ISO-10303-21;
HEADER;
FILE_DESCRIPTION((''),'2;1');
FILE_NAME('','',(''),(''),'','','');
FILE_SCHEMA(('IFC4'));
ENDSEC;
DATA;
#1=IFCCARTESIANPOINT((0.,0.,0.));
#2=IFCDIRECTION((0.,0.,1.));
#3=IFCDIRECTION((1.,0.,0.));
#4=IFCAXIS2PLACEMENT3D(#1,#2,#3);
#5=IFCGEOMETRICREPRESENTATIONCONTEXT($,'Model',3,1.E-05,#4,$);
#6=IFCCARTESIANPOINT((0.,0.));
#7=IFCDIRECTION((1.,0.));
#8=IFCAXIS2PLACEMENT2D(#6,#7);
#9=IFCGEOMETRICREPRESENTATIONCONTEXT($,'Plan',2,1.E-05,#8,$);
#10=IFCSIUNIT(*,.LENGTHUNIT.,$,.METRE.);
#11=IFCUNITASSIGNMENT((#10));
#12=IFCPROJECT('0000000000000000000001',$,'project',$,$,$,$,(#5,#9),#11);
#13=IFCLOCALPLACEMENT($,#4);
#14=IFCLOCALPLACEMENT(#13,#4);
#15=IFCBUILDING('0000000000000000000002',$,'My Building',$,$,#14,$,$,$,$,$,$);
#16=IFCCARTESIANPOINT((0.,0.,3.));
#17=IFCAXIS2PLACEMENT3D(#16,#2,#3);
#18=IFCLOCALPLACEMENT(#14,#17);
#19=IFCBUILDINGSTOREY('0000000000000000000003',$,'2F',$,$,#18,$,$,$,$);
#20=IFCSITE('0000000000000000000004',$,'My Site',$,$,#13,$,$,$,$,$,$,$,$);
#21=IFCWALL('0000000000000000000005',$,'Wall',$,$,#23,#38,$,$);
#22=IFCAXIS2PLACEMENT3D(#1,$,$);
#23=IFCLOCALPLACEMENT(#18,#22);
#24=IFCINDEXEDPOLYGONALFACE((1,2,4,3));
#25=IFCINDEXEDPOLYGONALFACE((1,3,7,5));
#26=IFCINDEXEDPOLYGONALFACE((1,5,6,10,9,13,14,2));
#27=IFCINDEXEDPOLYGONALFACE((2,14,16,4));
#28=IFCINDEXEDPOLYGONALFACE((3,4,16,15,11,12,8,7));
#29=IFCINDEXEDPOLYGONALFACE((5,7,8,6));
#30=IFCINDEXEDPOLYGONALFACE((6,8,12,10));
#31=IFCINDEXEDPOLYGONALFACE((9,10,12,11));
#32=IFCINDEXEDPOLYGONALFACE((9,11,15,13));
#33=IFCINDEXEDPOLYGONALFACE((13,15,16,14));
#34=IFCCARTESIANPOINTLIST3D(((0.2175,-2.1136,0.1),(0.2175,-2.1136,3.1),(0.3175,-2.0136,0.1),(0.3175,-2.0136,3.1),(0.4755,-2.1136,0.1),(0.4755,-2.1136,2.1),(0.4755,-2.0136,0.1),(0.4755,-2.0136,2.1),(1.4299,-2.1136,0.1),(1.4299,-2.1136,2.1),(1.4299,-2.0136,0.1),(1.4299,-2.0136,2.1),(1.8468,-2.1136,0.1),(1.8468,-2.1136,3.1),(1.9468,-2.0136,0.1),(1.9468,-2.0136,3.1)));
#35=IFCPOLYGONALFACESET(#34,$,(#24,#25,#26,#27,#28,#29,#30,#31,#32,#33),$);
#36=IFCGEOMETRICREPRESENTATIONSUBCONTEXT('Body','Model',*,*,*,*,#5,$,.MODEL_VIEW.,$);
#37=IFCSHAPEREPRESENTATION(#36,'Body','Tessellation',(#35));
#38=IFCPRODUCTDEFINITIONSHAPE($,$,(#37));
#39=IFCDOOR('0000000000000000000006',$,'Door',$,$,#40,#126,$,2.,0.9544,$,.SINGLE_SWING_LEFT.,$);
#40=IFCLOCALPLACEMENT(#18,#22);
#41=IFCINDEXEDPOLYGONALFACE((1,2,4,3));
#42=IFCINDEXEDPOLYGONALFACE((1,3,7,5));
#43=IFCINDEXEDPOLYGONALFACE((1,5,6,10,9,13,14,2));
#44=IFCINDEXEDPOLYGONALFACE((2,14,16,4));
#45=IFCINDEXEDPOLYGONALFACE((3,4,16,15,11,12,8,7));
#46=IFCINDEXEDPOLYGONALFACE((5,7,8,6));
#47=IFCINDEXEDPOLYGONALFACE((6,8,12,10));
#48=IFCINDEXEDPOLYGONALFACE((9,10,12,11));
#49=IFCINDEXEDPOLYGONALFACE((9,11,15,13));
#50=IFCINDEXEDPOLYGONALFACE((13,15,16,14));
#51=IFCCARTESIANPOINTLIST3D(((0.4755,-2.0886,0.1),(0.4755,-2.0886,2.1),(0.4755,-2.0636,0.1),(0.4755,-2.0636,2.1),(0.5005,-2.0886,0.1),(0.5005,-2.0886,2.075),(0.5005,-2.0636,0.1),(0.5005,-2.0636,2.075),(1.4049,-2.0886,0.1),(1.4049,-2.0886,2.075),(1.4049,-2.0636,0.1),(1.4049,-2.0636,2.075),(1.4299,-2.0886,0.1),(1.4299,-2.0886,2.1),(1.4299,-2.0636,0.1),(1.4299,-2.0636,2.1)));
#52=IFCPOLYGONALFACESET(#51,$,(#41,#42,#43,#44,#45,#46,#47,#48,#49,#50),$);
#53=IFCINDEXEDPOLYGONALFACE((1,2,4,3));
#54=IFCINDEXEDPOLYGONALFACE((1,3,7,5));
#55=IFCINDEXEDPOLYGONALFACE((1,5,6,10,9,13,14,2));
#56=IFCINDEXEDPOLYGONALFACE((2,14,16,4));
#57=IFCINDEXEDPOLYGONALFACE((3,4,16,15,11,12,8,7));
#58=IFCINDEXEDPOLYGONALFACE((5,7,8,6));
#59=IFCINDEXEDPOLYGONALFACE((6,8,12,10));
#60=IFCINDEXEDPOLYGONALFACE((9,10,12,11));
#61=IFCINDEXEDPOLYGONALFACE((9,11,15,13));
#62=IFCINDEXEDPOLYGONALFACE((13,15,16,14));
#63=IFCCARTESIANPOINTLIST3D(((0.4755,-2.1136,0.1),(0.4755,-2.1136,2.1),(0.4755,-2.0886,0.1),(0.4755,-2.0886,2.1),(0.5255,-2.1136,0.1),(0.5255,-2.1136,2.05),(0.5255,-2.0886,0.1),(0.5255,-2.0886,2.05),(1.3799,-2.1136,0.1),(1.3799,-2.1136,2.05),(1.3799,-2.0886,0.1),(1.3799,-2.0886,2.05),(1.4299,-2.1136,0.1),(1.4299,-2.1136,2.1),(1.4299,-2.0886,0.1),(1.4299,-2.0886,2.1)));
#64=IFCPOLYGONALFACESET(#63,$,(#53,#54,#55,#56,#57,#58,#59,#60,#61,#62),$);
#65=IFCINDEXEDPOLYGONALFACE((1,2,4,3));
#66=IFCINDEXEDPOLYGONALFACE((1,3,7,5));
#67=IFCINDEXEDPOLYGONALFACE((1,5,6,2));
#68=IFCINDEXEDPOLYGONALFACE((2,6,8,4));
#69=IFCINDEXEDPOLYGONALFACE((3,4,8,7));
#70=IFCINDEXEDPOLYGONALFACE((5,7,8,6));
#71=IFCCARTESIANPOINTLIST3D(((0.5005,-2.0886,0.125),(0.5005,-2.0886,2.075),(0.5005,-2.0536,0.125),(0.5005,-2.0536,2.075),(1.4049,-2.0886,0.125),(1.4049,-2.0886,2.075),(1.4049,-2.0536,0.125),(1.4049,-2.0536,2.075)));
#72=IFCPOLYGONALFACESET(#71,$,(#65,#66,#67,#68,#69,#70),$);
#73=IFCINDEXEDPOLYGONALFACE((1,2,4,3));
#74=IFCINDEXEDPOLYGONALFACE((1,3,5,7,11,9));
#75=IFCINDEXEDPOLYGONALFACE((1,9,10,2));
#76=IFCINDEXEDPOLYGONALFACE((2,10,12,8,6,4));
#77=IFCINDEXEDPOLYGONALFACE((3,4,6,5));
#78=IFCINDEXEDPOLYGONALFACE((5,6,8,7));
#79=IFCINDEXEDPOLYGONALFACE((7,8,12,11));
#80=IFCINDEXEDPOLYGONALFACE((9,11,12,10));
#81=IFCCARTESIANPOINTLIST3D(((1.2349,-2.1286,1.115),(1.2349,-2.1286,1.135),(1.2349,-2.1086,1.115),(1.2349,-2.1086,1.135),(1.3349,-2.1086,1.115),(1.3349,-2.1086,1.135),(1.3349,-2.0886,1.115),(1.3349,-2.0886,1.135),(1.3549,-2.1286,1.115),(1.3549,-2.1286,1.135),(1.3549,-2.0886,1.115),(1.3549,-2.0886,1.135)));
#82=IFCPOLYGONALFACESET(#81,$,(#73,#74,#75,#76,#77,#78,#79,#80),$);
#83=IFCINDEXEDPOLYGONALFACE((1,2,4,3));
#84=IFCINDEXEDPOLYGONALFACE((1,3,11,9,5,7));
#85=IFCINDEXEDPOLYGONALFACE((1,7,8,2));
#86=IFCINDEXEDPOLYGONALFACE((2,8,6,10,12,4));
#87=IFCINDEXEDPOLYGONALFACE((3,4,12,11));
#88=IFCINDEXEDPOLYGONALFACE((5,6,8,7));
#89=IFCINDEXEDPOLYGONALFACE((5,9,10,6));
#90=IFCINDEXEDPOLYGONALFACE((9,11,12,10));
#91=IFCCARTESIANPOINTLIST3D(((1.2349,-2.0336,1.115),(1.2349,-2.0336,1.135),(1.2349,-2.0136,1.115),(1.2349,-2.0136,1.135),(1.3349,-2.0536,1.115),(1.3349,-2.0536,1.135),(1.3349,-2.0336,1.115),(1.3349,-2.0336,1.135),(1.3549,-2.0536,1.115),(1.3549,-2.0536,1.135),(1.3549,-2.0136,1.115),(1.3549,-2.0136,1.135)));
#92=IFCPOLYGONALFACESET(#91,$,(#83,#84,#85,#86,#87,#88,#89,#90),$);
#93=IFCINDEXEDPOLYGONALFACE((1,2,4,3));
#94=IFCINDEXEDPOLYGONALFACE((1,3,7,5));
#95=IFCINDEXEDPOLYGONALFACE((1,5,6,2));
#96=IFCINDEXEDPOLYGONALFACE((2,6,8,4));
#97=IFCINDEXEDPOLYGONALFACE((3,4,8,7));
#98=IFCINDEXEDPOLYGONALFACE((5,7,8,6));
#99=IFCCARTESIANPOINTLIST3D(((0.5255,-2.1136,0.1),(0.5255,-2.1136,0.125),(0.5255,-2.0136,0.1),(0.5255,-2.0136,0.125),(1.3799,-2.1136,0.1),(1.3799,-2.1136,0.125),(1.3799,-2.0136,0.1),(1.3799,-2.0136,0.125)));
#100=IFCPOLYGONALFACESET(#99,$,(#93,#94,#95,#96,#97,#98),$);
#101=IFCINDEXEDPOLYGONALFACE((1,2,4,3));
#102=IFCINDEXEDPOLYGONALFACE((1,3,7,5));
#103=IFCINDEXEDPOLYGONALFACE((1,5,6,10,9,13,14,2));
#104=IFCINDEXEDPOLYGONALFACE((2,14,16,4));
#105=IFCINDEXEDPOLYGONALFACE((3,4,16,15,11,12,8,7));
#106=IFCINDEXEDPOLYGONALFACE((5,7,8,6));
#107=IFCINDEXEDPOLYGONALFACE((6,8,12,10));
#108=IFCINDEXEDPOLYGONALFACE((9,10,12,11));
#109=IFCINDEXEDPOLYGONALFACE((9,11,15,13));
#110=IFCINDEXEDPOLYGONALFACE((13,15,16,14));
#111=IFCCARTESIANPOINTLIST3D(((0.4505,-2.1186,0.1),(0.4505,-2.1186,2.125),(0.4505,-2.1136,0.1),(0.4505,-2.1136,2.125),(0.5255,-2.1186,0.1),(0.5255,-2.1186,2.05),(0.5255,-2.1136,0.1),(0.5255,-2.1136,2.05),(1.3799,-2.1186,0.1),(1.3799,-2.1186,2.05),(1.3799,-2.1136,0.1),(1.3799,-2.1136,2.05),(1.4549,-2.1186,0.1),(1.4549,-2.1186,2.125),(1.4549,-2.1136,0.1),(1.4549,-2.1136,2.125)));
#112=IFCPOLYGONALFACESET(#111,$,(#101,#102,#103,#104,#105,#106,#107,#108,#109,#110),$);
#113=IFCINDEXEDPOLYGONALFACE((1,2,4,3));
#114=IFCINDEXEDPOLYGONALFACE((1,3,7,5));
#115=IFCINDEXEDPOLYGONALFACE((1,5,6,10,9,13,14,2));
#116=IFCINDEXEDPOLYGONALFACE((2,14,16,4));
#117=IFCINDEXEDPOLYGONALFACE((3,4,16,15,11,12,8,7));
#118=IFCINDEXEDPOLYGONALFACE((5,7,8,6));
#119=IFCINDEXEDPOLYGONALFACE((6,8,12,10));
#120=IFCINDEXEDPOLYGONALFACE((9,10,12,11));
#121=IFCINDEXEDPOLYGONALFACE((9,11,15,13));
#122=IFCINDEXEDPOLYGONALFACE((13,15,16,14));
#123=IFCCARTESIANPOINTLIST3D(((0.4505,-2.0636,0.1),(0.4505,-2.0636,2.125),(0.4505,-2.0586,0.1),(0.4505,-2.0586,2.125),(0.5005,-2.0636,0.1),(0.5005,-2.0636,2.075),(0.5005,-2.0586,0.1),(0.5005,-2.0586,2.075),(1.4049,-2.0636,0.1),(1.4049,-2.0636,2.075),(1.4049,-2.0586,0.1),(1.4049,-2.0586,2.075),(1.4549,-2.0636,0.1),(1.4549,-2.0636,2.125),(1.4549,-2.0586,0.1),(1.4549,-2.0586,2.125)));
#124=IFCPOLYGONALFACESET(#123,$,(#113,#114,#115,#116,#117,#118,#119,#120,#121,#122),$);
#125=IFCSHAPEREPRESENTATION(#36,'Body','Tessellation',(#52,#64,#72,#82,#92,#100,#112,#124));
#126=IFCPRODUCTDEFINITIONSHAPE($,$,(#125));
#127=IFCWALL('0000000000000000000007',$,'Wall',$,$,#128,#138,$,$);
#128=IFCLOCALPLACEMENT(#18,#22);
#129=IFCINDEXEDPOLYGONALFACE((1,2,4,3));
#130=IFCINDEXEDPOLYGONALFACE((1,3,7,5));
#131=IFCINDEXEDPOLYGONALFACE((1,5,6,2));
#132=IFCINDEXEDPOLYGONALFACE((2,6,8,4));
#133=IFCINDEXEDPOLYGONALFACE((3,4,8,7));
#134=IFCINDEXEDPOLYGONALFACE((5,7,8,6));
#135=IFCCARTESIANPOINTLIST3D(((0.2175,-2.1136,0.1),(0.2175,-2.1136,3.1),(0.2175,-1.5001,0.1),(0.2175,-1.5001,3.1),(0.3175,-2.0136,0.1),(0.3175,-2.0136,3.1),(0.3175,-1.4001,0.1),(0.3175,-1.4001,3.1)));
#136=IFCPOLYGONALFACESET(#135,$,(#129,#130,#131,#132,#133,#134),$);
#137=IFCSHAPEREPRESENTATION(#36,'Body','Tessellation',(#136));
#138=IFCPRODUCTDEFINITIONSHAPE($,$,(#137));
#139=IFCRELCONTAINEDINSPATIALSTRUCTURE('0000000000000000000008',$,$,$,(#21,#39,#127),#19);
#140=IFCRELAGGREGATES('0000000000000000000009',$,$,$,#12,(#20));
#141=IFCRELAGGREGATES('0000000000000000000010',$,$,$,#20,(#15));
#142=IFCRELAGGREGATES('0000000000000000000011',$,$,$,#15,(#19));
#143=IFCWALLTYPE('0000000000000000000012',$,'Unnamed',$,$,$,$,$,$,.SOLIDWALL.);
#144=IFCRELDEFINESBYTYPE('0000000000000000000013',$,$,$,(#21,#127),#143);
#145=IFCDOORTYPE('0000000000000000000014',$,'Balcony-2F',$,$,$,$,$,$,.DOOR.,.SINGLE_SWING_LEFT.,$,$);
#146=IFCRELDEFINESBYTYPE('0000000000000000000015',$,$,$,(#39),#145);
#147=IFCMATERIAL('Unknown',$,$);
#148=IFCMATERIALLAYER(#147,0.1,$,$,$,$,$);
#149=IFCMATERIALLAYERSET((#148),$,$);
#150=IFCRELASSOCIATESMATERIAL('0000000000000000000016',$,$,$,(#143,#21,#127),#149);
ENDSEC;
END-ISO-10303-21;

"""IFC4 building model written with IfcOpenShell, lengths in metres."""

from ifc_helpers import new_model, entity, si_unit, frame, origin_with_axes, origin_2d_with_axis, place, context, subcontext, project, spatial, line, indexed_curve, outline, extrude, shape, source, transform, mapped, material, layer, layer_set, layer_usage, type_object, type_shapes, element, fill, save


model = new_model("IFC4")

# Units and contexts
model_context = context("Model", 3, precision=1e-05, world=origin_with_axes())
plan_context = context("Plan", 2, precision=1e-05, world=origin_2d_with_axis())
body_context_1 = subcontext(model_context, "Body", "Model", "MODEL_VIEW")
body_context_2 = subcontext(plan_context, "Body", "Plan", "PLAN_VIEW")
ifc_project = project(units=[si_unit("LENGTHUNIT", "METRE")], contexts=[model_context, plan_context])

# Site, building, storey
site_placement = place(None, origin_with_axes())
site = spatial("IfcSite", under=ifc_project, at=site_placement, Name="My Site")
building_placement = place(site_placement, origin_with_axes())
building = spatial("IfcBuilding", under=site, at=building_placement, Name="My Building")
storey_placement = place(building_placement, frame((0.0, 0.0, 3.0), z_axis=(0.0, 0.0, 1.0), x_axis=(1.0, 0.0, 0.0)))
storey = spatial("IfcBuildingStorey", under=building, at=storey_placement, Name="2F")

# Shared definitions
ifc_material = material(Name="Unknown")

# Shared definitions
ifc_layer_1 = layer(ifc_material, 0.1)
ifc_layer_set_1 = layer_set([ifc_layer_1])
wall_type = type_object("IfcWallType", Name="Unnamed", PredefinedType="SOLIDWALL", material=ifc_layer_set_1)

# Wall, opening, door
ifc_layer_usage_1 = layer_usage(ifc_layer_set_1, "AXIS2", "POSITIVE", 0.0)
wall_1_placement = place(storey_placement, frame((1.9468, -2.0136, 0.1), z_axis=(0.0, 0.0, 1.0), x_axis=(-1.0, 0.0, 0.0)))
wall_1 = element("IfcWall", 1, at=wall_1_placement, inside=storey, type_object=wall_type, material=ifc_layer_usage_1, Name="Wall", context=body_context_1, shape_type="SweptSolid", body=[
    extrude(outline(indexed_curve([(0.0, 0.0), (0.1, 0.1), (1.7294, 0.1), (1.6294, 0.0)], segments=[line(1, 2, 3, 4, 1)])), origin_with_axes(), (0.0, 0.0, 1.0), 3.0),
])
shared_shape_1 = source(origin_with_axes(), body_context_1, "Body", "SweptSolid", [
    extrude(outline(indexed_curve([(0.0, 0.0), (0.9544, 0.0), (0.9544, 2.0), (0.0, 2.0)], segments=[line(1, 2, 3, 4, 1)])), frame((0.0, -0.6, 0.0), z_axis=(0.0, -1.0, 0.0), x_axis=(1.0, 0.0, 0.0)), (0.0, 0.0, -1.0), 1.2),
])
opening_1_placement = place(wall_1_placement, frame((1.4713, 0.1, 0.0), z_axis=(0.0, 0.0, 1.0), x_axis=(-1.0, 0.0, 0.0)))
opening_1 = element("IfcOpeningElement", 2, at=opening_1_placement, cuts=wall_1, PredefinedType="OPENING", context=body_context_1, shape_type="MappedRepresentation", body=[
    mapped(shared_shape_1, transform((0.0, 0.0, 0.0), x_axis=(1.0, 0.0, 0.0), y_axis=(0.0, 1.0, 0.0), z_axis=(0.0, 0.0, 1.0), scale=1.0)),
])
door_type_1 = type_object("IfcDoorType", Name="Balcony-2F", OperationType="SINGLE_SWING_LEFT", PredefinedType="DOOR")
shared_shape_2 = source(origin_with_axes(), body_context_1, "Body", "SweptSolid", [
    extrude(outline(indexed_curve([(0.0, 0.0), (0.0, 2.0), (0.9544, 2.0), (0.9544, 0.0), (0.9294, 0.0), (0.9294, 1.975), (0.025, 1.975), (0.025, 0.0)], segments=[line(1, 2, 3, 4, 5, 6, 7, 8, 1)])), frame((0.0, 0.025, 0.0), z_axis=(0.0, -1.0, 0.0), x_axis=(1.0, 0.0, 0.0)), (0.0, 0.0, -1.0), 0.025),
    extrude(outline(indexed_curve([(0.0, 0.0), (0.0, 2.0), (0.9544, 2.0), (0.9544, 0.0), (0.9044, 0.0), (0.9044, 1.95), (0.05, 1.95), (0.05, 0.0)], segments=[line(1, 2, 3, 4, 5, 6, 7, 8, 1)])), frame((0.0, 0.0, 0.0), z_axis=(0.0, -1.0, 0.0), x_axis=(1.0, 0.0, 0.0)), (0.0, 0.0, -1.0), 0.025),
    extrude(outline(indexed_curve([(0.0, 0.0), (0.9044, 0.0), (0.9044, 0.035), (0.0, 0.035)], segments=[line(1, 2, 3, 4, 1)])), frame((0.025, 0.025, 0.025), z_axis=(0.0, 0.0, 1.0), x_axis=(1.0, 0.0, 0.0)), (0.0, 0.0, 1.0), 1.95),
    extrude(outline(indexed_curve([(0.0, 0.0), (0.0, -0.04), (-0.12, -0.04), (-0.12, -0.02), (-0.02, -0.02), (-0.02, 0.0)], segments=[line(1, 2, 3, 4, 5, 6, 1)])), frame((0.8794, 0.025, 1.015), z_axis=(0.0, 0.0, 1.0), x_axis=(1.0, 0.0, 0.0)), (0.0, 0.0, 1.0), 0.02),
    extrude(outline(indexed_curve([(0.0, 0.0), (0.0, 0.04), (-0.12, 0.04), (-0.12, 0.02), (-0.02, 0.02), (-0.02, 0.0)], segments=[line(1, 2, 3, 4, 5, 6, 1)])), frame((0.8794, 0.06, 1.015), z_axis=(0.0, 0.0, 1.0), x_axis=(1.0, 0.0, 0.0)), (0.0, 0.0, 1.0), 0.02),
    extrude(outline(indexed_curve([(0.0, 0.0), (0.8544, 0.0), (0.8544, 0.1), (0.0, 0.1)], segments=[line(1, 2, 3, 4, 1)])), frame((0.05, 0.0, 0.0), z_axis=(0.0, 0.0, 1.0), x_axis=(1.0, 0.0, 0.0)), (0.0, 0.0, 1.0), 0.025),
    extrude(outline(indexed_curve([(0.0, 0.0), (0.0, 2.025), (1.0044, 2.025), (1.0044, 0.0), (0.9294, 0.0), (0.9294, 1.95), (0.075, 1.95), (0.075, 0.0)], segments=[line(1, 2, 3, 4, 5, 6, 7, 8, 1)])), frame((-0.025, -0.005, 0.0), z_axis=(0.0, -1.0, 0.0), x_axis=(1.0, 0.0, 0.0)), (0.0, 0.0, -1.0), 0.005),
    extrude(outline(indexed_curve([(0.0, 0.0), (0.0, 2.025), (1.0044, 2.025), (1.0044, 0.0), (0.9544, 0.0), (0.9544, 1.975), (0.05, 1.975), (0.05, 0.0)], segments=[line(1, 2, 3, 4, 5, 6, 7, 8, 1)])), frame((-0.025, 0.05, 0.0), z_axis=(0.0, -1.0, 0.0), x_axis=(1.0, 0.0, 0.0)), (0.0, 0.0, -1.0), 0.005),
])
shared_shape_3 = source(origin_with_axes(), body_context_2, "Body", "Curve2D", [
    entity("IfcIndexedPolyCurve", entity("IfcCartesianPointList2D", [[0.0, 0.0], [0.0, 0.05], [0.025, 0.05], [0.025, 0.025], [0.05, 0.025], [0.05, 0.0]]), [entity("IfcLineIndex", [1, 2, 3, 4, 5, 6, 1])]),
    entity("IfcIndexedPolyCurve", entity("IfcCartesianPointList2D", [[0.9544, 0.0], [0.9544, 0.05], [0.9294, 0.05], [0.9294, 0.025], [0.9044, 0.025], [0.9044, 0.0]]), [entity("IfcLineIndex", [1, 2, 3, 4, 5, 6, 1])]),
    entity("IfcTrimmedCurve", entity("IfcEllipse", entity("IfcAxis2Placement2D", entity("IfcCartesianPoint", [0.06, 0.05]), entity("IfcDirection", [1.0, 0.0])), 0.8694, 0.9044), [entity("IfcCartesianPoint", [0.9294, 0.05])], [entity("IfcCartesianPoint", [0.06, 0.9544])], True, "CARTESIAN"),
    entity("IfcIndexedPolyCurve", entity("IfcCartesianPointList2D", [[0.025, 0.05], [0.06, 0.05], [0.06, 0.9544], [0.025, 0.9544]]), [entity("IfcLineIndex", [1, 2, 3, 4, 1])]),
])
type_shapes(door_type_1, [shared_shape_2, shared_shape_3])
door_1_placement = place(opening_1_placement, frame((0.0, 0.0, 0.0), z_axis=(0.0, 0.0, 1.0), x_axis=(1.0, 0.0, 0.0)))
door_1 = element("IfcDoor", 3, at=door_1_placement, inside=storey, type_object=door_type_1, Name="Door", OperationType="SINGLE_SWING_LEFT", OverallHeight=2.0, OverallWidth=0.9544, shapes=[
    shape(body_context_1, "Body", "MappedRepresentation", [mapped(shared_shape_2, transform((0.0, 0.0, 0.0), x_axis=(1.0, 0.0, 0.0), y_axis=(0.0, 1.0, 0.0), z_axis=(0.0, 0.0, 1.0), scale=1.0))]),
    shape(body_context_2, "Body", "MappedRepresentation", [mapped(shared_shape_3, transform((0.0, 0.0, 0.0), x_axis=(1.0, 0.0, 0.0), y_axis=(0.0, 1.0, 0.0), z_axis=(0.0, 0.0, 1.0), scale=1.0))]),
])
fill(opening_1, door_1)

# Wall
ifc_layer_usage_2 = layer_usage(ifc_layer_set_1, "AXIS2", "POSITIVE", 0.0)
wall_2_placement = place(storey_placement, frame((0.3175, -2.0136, 0.1), z_axis=(0.0, 0.0, 1.0), x_axis=(0.0, 1.0, 0.0)))
element("IfcWall", 4, at=wall_2_placement, inside=storey, type_object=wall_type, material=ifc_layer_usage_2, Name="Wall", context=body_context_1, shape_type="SweptSolid", body=[
    extrude(outline(indexed_curve([(0.0, 0.0), (-0.1, 0.1), (0.5135, 0.1), (0.6135, 0.0)], segments=[line(1, 2, 3, 4, 1)])), origin_with_axes(), (0.0, 0.0, 1.0), 3.0),
])

save(model, "model.ifc")
